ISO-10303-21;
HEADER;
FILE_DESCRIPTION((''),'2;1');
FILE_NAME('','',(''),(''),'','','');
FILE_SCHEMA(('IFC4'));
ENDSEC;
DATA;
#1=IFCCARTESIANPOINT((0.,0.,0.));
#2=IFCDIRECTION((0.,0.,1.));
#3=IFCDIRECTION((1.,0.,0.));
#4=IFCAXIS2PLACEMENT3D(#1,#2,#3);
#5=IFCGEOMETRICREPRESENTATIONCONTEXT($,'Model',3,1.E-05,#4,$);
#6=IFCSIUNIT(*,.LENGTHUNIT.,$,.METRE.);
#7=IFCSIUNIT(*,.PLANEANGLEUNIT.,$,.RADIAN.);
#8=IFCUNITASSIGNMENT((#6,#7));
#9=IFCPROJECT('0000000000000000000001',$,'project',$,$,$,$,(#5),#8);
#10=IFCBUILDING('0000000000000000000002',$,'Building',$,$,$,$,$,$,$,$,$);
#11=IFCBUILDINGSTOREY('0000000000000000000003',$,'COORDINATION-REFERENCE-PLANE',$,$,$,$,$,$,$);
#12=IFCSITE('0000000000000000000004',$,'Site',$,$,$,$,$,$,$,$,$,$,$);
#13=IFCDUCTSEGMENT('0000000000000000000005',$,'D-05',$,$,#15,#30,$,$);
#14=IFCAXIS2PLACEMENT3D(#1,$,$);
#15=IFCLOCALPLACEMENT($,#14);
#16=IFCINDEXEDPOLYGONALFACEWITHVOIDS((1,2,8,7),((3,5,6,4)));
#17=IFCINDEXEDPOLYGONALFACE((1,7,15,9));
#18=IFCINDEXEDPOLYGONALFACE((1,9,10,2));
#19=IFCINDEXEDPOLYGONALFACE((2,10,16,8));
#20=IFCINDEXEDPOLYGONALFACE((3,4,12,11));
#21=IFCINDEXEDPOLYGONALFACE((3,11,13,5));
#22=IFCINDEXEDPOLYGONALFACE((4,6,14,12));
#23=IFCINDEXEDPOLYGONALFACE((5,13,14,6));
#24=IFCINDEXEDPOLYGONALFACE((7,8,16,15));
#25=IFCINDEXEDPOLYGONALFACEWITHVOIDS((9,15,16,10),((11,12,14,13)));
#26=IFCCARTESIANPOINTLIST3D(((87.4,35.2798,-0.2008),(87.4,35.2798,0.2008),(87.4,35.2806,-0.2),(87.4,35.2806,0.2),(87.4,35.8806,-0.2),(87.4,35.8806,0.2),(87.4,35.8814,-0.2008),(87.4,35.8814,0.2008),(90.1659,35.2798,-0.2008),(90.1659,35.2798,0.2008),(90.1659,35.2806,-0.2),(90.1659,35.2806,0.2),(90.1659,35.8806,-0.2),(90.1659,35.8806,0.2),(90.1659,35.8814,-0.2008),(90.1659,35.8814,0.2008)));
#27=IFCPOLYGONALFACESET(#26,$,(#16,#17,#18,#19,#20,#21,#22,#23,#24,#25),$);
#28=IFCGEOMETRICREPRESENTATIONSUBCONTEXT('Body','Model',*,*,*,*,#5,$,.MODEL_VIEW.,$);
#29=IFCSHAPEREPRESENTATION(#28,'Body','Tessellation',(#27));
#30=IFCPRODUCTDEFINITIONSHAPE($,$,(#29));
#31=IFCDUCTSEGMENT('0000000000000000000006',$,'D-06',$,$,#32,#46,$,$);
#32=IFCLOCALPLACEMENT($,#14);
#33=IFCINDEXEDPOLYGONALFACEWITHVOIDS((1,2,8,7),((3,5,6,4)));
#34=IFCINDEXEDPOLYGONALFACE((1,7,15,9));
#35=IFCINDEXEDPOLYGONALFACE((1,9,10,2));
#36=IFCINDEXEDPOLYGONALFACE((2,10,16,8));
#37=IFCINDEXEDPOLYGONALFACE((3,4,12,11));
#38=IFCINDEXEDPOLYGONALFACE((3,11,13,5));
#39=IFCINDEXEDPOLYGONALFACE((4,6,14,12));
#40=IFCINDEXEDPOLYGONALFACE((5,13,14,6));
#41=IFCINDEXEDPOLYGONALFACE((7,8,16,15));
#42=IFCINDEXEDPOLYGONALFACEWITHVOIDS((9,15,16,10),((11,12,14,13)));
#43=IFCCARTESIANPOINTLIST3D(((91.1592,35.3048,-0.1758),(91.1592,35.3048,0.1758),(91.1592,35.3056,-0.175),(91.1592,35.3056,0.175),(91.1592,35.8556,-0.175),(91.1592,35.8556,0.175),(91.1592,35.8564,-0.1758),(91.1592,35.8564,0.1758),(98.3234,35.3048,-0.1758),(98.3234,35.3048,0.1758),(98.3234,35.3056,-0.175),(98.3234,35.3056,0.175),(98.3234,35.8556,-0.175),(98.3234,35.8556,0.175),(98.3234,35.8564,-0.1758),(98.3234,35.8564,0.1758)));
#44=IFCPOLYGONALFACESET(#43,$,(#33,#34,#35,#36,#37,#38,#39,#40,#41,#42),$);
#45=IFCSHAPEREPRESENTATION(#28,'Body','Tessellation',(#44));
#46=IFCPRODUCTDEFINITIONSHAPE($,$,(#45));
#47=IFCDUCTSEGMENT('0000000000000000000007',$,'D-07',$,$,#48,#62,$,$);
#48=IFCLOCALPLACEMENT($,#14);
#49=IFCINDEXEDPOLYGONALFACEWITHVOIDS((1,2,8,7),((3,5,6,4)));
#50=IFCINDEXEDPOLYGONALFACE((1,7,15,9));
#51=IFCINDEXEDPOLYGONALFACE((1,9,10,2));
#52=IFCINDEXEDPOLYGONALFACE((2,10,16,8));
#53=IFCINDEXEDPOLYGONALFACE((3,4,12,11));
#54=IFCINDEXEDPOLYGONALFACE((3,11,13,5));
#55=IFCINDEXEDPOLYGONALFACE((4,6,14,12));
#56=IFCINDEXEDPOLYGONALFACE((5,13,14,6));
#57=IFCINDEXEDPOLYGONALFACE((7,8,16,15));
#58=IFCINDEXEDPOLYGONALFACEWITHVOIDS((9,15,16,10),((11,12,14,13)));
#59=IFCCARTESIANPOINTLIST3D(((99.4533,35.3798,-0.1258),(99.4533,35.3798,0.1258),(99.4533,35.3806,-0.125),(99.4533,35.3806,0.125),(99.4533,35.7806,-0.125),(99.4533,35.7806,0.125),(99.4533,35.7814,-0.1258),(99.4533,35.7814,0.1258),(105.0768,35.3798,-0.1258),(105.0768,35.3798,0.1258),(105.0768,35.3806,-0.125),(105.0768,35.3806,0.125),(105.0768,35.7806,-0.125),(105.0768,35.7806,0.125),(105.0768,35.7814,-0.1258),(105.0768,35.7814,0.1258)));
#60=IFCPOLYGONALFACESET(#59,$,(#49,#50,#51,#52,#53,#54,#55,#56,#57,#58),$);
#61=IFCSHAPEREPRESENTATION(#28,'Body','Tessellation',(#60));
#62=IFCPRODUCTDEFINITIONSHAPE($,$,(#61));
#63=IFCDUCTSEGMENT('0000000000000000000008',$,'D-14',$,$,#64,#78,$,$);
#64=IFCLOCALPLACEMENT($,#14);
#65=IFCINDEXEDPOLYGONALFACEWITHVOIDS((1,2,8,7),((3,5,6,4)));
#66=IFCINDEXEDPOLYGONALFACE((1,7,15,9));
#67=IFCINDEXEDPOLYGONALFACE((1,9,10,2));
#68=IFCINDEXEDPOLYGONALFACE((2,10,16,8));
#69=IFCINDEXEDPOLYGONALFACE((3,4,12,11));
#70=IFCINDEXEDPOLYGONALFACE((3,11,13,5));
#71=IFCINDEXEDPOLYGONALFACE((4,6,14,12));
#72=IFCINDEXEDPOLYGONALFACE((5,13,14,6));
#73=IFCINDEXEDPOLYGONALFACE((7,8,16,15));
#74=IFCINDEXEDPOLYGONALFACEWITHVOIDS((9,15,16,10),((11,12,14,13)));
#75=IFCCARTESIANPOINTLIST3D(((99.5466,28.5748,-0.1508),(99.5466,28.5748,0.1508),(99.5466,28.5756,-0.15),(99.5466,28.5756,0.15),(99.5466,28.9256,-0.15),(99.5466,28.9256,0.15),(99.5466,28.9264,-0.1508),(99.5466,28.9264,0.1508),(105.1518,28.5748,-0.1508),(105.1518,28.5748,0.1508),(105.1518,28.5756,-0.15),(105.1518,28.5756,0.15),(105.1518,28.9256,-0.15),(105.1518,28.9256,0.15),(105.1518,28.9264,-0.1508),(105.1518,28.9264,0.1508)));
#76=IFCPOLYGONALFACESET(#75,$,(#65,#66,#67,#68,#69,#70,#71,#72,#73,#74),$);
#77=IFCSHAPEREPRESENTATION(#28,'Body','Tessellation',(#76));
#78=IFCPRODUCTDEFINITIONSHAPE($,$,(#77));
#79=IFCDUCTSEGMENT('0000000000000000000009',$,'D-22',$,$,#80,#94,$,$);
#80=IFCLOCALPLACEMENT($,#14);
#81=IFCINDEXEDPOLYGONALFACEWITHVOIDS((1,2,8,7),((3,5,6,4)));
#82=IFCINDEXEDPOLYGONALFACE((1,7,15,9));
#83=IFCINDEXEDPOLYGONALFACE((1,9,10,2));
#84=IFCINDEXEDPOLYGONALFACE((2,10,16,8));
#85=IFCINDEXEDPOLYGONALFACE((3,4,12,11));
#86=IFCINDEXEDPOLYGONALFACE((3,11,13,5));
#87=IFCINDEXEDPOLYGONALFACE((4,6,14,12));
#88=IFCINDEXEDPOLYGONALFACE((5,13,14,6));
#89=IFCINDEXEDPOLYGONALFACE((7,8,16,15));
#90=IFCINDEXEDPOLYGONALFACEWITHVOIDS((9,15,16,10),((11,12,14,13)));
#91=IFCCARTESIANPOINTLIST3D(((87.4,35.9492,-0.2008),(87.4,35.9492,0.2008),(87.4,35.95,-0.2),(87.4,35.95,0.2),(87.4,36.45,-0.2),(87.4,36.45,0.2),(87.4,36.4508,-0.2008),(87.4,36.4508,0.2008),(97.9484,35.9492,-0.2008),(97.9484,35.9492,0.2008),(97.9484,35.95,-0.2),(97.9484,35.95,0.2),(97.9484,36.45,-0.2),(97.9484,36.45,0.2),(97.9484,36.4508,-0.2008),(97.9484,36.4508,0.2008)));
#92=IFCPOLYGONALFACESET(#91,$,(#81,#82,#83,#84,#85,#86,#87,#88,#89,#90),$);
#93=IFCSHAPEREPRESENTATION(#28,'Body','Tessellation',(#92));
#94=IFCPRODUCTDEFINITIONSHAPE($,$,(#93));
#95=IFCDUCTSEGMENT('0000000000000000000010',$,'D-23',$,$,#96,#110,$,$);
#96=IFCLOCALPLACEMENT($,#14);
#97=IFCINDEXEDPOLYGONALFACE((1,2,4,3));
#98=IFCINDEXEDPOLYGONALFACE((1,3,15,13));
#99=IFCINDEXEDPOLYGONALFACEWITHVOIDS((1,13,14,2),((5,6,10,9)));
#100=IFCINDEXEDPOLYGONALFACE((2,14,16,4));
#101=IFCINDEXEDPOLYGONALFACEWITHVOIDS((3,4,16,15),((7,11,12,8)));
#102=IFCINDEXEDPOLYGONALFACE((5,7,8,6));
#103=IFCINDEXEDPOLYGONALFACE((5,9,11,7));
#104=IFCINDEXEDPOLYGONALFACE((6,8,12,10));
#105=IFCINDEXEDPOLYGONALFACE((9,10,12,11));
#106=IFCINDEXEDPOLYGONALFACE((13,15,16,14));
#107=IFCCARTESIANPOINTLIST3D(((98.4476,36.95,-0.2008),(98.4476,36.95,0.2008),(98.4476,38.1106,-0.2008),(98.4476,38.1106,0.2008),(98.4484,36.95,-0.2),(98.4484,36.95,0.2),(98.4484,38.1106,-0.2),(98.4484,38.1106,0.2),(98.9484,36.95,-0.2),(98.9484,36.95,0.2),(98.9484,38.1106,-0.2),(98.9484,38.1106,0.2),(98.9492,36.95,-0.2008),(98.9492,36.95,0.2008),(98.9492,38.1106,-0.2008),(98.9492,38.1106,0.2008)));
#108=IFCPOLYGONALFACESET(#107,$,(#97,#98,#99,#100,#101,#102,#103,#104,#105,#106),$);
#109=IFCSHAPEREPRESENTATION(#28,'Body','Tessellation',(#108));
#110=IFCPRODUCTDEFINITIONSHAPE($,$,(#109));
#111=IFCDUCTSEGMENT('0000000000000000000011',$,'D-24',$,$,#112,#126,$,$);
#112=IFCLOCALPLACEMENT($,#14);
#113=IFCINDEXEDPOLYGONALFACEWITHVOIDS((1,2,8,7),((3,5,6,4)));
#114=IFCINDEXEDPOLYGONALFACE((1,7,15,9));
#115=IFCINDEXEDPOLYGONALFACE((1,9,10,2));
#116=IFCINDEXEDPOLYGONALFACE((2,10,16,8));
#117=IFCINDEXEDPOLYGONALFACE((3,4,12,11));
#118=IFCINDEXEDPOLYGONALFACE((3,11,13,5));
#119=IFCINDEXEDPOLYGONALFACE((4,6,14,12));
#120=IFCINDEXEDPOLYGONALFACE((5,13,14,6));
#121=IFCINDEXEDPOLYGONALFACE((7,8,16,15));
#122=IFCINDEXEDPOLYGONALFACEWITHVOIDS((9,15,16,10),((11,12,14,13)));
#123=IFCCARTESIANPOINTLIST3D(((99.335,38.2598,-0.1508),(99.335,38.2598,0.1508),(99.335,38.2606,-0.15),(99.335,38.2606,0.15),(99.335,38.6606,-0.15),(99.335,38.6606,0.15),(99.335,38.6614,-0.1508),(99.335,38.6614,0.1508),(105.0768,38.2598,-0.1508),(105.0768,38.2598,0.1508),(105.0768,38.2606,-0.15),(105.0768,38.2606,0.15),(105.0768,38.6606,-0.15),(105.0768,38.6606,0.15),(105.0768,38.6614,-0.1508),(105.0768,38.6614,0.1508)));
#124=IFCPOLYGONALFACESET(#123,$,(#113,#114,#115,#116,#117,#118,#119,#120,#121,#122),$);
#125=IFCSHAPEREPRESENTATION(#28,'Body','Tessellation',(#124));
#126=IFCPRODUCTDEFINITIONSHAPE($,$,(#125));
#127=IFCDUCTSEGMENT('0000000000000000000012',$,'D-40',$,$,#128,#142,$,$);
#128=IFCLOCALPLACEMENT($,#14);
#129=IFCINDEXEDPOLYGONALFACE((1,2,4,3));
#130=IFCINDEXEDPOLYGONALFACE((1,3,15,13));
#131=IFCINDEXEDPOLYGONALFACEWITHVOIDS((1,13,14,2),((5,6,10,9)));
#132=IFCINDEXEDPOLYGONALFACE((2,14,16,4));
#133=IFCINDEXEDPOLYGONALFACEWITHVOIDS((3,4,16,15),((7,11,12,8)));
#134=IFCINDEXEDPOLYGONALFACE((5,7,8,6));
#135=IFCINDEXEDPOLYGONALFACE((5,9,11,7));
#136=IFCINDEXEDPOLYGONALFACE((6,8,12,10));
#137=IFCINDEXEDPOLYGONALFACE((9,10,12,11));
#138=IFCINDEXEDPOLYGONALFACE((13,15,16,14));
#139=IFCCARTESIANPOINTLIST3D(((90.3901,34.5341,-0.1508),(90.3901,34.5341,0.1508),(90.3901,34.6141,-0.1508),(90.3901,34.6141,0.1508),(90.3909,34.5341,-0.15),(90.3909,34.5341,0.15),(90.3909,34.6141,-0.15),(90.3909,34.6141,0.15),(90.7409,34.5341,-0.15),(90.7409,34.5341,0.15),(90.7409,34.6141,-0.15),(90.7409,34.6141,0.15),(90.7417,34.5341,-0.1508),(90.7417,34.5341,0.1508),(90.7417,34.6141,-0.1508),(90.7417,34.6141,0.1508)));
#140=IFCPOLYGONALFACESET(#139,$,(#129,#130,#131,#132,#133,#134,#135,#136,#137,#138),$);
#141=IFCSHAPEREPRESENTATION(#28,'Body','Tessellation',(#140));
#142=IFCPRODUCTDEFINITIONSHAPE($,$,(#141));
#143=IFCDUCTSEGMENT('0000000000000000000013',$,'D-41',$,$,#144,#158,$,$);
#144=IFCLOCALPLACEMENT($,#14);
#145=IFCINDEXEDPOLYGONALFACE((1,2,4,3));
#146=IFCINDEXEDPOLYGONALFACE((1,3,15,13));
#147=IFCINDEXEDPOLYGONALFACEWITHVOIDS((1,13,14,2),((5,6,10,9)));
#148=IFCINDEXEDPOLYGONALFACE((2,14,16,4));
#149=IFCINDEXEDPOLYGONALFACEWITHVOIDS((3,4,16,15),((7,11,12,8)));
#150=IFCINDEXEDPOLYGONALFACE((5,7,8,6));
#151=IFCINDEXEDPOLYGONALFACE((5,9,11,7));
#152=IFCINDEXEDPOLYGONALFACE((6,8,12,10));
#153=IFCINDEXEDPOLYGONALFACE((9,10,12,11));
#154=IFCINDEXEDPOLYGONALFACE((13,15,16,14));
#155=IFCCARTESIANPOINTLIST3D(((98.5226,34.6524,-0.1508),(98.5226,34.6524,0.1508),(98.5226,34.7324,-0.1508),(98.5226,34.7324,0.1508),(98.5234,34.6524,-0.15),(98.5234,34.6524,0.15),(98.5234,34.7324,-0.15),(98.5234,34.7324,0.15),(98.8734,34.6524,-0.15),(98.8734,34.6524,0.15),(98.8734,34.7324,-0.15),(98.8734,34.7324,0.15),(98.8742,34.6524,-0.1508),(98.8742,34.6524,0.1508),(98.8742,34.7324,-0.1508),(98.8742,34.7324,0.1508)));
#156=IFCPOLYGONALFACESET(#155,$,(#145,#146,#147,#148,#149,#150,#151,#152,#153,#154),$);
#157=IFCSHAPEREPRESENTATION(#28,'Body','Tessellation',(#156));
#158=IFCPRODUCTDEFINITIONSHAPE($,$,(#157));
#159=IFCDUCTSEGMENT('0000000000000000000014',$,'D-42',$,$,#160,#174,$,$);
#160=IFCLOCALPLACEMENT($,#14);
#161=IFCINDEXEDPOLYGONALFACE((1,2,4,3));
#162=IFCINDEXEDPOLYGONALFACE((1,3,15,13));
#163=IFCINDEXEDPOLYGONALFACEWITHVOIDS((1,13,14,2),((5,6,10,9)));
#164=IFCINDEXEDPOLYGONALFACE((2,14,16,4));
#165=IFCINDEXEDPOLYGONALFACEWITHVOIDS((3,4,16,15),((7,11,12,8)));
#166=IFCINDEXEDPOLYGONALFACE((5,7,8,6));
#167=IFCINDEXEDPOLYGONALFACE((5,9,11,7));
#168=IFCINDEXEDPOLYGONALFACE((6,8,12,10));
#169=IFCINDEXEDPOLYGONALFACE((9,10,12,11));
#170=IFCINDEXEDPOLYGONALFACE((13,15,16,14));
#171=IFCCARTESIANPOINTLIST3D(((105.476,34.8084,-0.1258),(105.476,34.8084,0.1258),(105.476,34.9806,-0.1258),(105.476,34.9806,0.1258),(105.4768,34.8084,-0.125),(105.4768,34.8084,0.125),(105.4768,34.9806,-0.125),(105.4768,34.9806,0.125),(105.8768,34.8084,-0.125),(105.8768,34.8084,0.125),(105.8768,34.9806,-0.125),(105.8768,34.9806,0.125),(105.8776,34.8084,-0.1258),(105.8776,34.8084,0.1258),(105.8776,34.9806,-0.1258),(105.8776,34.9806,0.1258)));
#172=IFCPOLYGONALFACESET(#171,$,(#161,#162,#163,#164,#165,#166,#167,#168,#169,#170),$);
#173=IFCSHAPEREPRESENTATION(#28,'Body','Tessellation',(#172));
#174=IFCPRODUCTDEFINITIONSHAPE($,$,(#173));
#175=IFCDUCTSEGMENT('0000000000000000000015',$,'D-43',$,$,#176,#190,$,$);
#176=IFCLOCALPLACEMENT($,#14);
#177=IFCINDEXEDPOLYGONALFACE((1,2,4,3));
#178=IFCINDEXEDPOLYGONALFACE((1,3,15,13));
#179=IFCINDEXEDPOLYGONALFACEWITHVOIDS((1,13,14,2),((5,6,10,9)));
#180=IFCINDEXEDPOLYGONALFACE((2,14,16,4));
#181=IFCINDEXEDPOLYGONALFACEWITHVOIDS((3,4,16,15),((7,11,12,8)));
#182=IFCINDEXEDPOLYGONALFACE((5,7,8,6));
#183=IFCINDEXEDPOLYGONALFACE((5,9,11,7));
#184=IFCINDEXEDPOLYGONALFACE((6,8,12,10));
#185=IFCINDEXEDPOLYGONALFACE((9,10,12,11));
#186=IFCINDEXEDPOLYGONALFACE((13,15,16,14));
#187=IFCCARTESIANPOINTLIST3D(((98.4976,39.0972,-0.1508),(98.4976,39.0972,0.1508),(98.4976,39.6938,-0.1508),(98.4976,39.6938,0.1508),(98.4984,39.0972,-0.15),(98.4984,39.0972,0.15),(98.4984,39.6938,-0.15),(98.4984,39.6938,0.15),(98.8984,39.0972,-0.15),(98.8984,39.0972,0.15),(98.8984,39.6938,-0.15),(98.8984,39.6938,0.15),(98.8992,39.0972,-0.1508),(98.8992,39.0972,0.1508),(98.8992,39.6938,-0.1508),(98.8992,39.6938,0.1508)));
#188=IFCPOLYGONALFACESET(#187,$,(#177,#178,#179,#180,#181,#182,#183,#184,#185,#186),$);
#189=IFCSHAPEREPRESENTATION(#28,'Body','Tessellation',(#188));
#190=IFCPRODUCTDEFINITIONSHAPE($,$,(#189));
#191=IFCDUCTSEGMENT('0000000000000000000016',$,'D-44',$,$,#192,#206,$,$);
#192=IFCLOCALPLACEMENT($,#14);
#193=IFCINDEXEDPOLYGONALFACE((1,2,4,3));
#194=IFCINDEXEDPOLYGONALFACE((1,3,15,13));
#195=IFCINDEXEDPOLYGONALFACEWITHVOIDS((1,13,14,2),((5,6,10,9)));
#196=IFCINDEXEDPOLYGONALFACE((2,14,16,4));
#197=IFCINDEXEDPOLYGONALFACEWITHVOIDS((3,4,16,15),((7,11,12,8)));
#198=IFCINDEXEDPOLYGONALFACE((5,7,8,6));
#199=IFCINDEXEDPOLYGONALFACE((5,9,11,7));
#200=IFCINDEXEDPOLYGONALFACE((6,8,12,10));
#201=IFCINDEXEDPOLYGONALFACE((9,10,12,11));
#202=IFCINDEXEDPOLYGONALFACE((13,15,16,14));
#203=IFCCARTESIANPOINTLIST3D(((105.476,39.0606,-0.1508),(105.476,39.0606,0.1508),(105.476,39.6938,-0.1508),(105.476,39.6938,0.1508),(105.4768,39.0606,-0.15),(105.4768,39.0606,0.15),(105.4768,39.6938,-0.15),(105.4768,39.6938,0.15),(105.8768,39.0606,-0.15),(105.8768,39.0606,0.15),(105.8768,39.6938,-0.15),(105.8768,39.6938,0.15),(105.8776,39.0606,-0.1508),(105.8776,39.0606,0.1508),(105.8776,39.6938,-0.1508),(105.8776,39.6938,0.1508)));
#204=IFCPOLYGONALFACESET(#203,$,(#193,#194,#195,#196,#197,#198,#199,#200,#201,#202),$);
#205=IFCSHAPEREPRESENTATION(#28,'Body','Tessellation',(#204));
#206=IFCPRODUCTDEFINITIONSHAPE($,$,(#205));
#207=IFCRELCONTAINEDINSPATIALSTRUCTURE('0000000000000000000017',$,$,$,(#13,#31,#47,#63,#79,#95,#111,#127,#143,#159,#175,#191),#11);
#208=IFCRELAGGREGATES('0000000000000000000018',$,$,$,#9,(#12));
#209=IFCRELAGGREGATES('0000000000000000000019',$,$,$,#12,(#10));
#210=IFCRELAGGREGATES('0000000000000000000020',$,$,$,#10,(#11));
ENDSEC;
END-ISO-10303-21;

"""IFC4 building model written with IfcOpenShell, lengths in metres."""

from ifc_helpers import new_model, si_unit, frame, origin, origin_with_axes, place, context, subcontext, project, spatial, hollow_rectangle, extrude, element, save


model = new_model("IFC4")

# Units and contexts
model_context = context("Model", 3, precision=1e-05, world=origin_with_axes())
body_context_1 = subcontext(model_context, "Body", "Model", "MODEL_VIEW")
ifc_project = project(units=[si_unit("LENGTHUNIT", "METRE"), si_unit("PLANEANGLEUNIT", "RADIAN")], contexts=[model_context])

# Site, building, storey
site = spatial("IfcSite", under=ifc_project, Name="Site")
building = spatial("IfcBuilding", under=site, Name="Building")
storey = spatial("IfcBuildingStorey", under=building, Name="COORDINATION-REFERENCE-PLANE")

# Duct segments
duct_segment_1_placement = place(None, frame((87.4, 35.5806, 0.0), z_axis=(1.0, 0.0, 0.0), x_axis=(0.0, 1.0, 0.0)))
element("IfcDuctSegment", 1, at=duct_segment_1_placement, inside=storey, Name="D-05", context=body_context_1, shape_type="SweptSolid", body=[
    extrude(hollow_rectangle(XDim=0.6016, YDim=0.4016, WallThickness=0.0008), origin(), (0.0, 0.0, 1.0), 2.7659),
])
duct_segment_2_placement = place(None, frame((91.1592, 35.5806, 0.0), z_axis=(1.0, 0.0, 0.0), x_axis=(0.0, 1.0, 0.0)))
element("IfcDuctSegment", 2, at=duct_segment_2_placement, inside=storey, Name="D-06", context=body_context_1, shape_type="SweptSolid", body=[
    extrude(hollow_rectangle(XDim=0.5516, YDim=0.3516, WallThickness=0.0008), origin(), (0.0, 0.0, 1.0), 7.1642),
])
duct_segment_3_placement = place(None, frame((99.4533, 35.5806, 0.0), z_axis=(1.0, 0.0, 0.0), x_axis=(0.0, 1.0, 0.0)))
element("IfcDuctSegment", 3, at=duct_segment_3_placement, inside=storey, Name="D-07", context=body_context_1, shape_type="SweptSolid", body=[
    extrude(hollow_rectangle(XDim=0.4016, YDim=0.2516, WallThickness=0.0008), origin(), (0.0, 0.0, 1.0), 5.6234),
])
duct_segment_4_placement = place(None, frame((99.5466, 28.7506, 0.0), z_axis=(1.0, 0.0, 0.0), x_axis=(0.0, 1.0, 0.0)))
element("IfcDuctSegment", 4, at=duct_segment_4_placement, inside=storey, Name="D-14", context=body_context_1, shape_type="SweptSolid", body=[
    extrude(hollow_rectangle(XDim=0.3516, YDim=0.3016, WallThickness=0.0008), origin(), (0.0, 0.0, 1.0), 5.6051),
])
duct_segment_5_placement = place(None, frame((87.4, 36.2, 0.0), z_axis=(1.0, 0.0, 0.0), x_axis=(0.0, 1.0, 0.0)))
element("IfcDuctSegment", 5, at=duct_segment_5_placement, inside=storey, Name="D-22", context=body_context_1, shape_type="SweptSolid", body=[
    extrude(hollow_rectangle(XDim=0.5016, YDim=0.4016, WallThickness=0.0008), origin(), (0.0, 0.0, 1.0), 10.5484),
])
duct_segment_6_placement = place(None, frame((98.6984, 36.95, 0.0), z_axis=(0.0, 1.0, 0.0), x_axis=(1.0, 0.0, 0.0)))
element("IfcDuctSegment", 6, at=duct_segment_6_placement, inside=storey, Name="D-23", context=body_context_1, shape_type="SweptSolid", body=[
    extrude(hollow_rectangle(XDim=0.5016, YDim=0.4016, WallThickness=0.0008), origin(), (0.0, 0.0, 1.0), 1.1606),
])
duct_segment_7_placement = place(None, frame((99.335, 38.4606, 0.0), z_axis=(1.0, 0.0, 0.0), x_axis=(0.0, 1.0, 0.0)))
element("IfcDuctSegment", 7, at=duct_segment_7_placement, inside=storey, Name="D-24", context=body_context_1, shape_type="SweptSolid", body=[
    extrude(hollow_rectangle(XDim=0.4016, YDim=0.3016, WallThickness=0.0008), origin(), (0.0, 0.0, 1.0), 5.7417),
])
for number, where, z_axis, x_axis, name in (
    (8, (90.5659, 34.5341, 0.0), (0.0, 1.0, 0.0), (1.0, 0.0, 0.0), "D-40"),
    (9, (98.6984, 34.6524, 0.0), (0.0, 1.0, 0.0), (1.0, 0.0, 0.0), "D-41"),
):
    element("IfcDuctSegment", number, at=place(None, frame(where, z_axis=z_axis, x_axis=x_axis)), inside=storey, Name=name, context=body_context_1, shape_type="SweptSolid", body=[
        extrude(hollow_rectangle(XDim=0.3516, YDim=0.3016, WallThickness=0.0008), origin(), (0.0, 0.0, 1.0), 0.08),
    ])
duct_segment_8_placement = place(None, frame((105.6768, 34.8084, 0.0), z_axis=(0.0, 1.0, 0.0), x_axis=(1.0, 0.0, 0.0)))
element("IfcDuctSegment", 10, at=duct_segment_8_placement, inside=storey, Name="D-42", context=body_context_1, shape_type="SweptSolid", body=[
    extrude(hollow_rectangle(XDim=0.4016, YDim=0.2516, WallThickness=0.0008), origin(), (0.0, 0.0, 1.0), 0.1721),
])
duct_segment_9_placement = place(None, frame((98.6984, 39.0972, 0.0), z_axis=(0.0, 1.0, 0.0), x_axis=(1.0, 0.0, 0.0)))
element("IfcDuctSegment", 11, at=duct_segment_9_placement, inside=storey, Name="D-43", context=body_context_1, shape_type="SweptSolid", body=[
    extrude(hollow_rectangle(XDim=0.4016, YDim=0.3016, WallThickness=0.0008), origin(), (0.0, 0.0, 1.0), 0.5966),
])
duct_segment_10_placement = place(None, frame((105.6768, 39.0606, 0.0), z_axis=(0.0, 1.0, 0.0), x_axis=(1.0, 0.0, 0.0)))
element("IfcDuctSegment", 12, at=duct_segment_10_placement, inside=storey, Name="D-44", context=body_context_1, shape_type="SweptSolid", body=[
    extrude(hollow_rectangle(XDim=0.4016, YDim=0.3016, WallThickness=0.0008), origin(), (0.0, 0.0, 1.0), 0.6332),
])

save(model, "model.ifc")
